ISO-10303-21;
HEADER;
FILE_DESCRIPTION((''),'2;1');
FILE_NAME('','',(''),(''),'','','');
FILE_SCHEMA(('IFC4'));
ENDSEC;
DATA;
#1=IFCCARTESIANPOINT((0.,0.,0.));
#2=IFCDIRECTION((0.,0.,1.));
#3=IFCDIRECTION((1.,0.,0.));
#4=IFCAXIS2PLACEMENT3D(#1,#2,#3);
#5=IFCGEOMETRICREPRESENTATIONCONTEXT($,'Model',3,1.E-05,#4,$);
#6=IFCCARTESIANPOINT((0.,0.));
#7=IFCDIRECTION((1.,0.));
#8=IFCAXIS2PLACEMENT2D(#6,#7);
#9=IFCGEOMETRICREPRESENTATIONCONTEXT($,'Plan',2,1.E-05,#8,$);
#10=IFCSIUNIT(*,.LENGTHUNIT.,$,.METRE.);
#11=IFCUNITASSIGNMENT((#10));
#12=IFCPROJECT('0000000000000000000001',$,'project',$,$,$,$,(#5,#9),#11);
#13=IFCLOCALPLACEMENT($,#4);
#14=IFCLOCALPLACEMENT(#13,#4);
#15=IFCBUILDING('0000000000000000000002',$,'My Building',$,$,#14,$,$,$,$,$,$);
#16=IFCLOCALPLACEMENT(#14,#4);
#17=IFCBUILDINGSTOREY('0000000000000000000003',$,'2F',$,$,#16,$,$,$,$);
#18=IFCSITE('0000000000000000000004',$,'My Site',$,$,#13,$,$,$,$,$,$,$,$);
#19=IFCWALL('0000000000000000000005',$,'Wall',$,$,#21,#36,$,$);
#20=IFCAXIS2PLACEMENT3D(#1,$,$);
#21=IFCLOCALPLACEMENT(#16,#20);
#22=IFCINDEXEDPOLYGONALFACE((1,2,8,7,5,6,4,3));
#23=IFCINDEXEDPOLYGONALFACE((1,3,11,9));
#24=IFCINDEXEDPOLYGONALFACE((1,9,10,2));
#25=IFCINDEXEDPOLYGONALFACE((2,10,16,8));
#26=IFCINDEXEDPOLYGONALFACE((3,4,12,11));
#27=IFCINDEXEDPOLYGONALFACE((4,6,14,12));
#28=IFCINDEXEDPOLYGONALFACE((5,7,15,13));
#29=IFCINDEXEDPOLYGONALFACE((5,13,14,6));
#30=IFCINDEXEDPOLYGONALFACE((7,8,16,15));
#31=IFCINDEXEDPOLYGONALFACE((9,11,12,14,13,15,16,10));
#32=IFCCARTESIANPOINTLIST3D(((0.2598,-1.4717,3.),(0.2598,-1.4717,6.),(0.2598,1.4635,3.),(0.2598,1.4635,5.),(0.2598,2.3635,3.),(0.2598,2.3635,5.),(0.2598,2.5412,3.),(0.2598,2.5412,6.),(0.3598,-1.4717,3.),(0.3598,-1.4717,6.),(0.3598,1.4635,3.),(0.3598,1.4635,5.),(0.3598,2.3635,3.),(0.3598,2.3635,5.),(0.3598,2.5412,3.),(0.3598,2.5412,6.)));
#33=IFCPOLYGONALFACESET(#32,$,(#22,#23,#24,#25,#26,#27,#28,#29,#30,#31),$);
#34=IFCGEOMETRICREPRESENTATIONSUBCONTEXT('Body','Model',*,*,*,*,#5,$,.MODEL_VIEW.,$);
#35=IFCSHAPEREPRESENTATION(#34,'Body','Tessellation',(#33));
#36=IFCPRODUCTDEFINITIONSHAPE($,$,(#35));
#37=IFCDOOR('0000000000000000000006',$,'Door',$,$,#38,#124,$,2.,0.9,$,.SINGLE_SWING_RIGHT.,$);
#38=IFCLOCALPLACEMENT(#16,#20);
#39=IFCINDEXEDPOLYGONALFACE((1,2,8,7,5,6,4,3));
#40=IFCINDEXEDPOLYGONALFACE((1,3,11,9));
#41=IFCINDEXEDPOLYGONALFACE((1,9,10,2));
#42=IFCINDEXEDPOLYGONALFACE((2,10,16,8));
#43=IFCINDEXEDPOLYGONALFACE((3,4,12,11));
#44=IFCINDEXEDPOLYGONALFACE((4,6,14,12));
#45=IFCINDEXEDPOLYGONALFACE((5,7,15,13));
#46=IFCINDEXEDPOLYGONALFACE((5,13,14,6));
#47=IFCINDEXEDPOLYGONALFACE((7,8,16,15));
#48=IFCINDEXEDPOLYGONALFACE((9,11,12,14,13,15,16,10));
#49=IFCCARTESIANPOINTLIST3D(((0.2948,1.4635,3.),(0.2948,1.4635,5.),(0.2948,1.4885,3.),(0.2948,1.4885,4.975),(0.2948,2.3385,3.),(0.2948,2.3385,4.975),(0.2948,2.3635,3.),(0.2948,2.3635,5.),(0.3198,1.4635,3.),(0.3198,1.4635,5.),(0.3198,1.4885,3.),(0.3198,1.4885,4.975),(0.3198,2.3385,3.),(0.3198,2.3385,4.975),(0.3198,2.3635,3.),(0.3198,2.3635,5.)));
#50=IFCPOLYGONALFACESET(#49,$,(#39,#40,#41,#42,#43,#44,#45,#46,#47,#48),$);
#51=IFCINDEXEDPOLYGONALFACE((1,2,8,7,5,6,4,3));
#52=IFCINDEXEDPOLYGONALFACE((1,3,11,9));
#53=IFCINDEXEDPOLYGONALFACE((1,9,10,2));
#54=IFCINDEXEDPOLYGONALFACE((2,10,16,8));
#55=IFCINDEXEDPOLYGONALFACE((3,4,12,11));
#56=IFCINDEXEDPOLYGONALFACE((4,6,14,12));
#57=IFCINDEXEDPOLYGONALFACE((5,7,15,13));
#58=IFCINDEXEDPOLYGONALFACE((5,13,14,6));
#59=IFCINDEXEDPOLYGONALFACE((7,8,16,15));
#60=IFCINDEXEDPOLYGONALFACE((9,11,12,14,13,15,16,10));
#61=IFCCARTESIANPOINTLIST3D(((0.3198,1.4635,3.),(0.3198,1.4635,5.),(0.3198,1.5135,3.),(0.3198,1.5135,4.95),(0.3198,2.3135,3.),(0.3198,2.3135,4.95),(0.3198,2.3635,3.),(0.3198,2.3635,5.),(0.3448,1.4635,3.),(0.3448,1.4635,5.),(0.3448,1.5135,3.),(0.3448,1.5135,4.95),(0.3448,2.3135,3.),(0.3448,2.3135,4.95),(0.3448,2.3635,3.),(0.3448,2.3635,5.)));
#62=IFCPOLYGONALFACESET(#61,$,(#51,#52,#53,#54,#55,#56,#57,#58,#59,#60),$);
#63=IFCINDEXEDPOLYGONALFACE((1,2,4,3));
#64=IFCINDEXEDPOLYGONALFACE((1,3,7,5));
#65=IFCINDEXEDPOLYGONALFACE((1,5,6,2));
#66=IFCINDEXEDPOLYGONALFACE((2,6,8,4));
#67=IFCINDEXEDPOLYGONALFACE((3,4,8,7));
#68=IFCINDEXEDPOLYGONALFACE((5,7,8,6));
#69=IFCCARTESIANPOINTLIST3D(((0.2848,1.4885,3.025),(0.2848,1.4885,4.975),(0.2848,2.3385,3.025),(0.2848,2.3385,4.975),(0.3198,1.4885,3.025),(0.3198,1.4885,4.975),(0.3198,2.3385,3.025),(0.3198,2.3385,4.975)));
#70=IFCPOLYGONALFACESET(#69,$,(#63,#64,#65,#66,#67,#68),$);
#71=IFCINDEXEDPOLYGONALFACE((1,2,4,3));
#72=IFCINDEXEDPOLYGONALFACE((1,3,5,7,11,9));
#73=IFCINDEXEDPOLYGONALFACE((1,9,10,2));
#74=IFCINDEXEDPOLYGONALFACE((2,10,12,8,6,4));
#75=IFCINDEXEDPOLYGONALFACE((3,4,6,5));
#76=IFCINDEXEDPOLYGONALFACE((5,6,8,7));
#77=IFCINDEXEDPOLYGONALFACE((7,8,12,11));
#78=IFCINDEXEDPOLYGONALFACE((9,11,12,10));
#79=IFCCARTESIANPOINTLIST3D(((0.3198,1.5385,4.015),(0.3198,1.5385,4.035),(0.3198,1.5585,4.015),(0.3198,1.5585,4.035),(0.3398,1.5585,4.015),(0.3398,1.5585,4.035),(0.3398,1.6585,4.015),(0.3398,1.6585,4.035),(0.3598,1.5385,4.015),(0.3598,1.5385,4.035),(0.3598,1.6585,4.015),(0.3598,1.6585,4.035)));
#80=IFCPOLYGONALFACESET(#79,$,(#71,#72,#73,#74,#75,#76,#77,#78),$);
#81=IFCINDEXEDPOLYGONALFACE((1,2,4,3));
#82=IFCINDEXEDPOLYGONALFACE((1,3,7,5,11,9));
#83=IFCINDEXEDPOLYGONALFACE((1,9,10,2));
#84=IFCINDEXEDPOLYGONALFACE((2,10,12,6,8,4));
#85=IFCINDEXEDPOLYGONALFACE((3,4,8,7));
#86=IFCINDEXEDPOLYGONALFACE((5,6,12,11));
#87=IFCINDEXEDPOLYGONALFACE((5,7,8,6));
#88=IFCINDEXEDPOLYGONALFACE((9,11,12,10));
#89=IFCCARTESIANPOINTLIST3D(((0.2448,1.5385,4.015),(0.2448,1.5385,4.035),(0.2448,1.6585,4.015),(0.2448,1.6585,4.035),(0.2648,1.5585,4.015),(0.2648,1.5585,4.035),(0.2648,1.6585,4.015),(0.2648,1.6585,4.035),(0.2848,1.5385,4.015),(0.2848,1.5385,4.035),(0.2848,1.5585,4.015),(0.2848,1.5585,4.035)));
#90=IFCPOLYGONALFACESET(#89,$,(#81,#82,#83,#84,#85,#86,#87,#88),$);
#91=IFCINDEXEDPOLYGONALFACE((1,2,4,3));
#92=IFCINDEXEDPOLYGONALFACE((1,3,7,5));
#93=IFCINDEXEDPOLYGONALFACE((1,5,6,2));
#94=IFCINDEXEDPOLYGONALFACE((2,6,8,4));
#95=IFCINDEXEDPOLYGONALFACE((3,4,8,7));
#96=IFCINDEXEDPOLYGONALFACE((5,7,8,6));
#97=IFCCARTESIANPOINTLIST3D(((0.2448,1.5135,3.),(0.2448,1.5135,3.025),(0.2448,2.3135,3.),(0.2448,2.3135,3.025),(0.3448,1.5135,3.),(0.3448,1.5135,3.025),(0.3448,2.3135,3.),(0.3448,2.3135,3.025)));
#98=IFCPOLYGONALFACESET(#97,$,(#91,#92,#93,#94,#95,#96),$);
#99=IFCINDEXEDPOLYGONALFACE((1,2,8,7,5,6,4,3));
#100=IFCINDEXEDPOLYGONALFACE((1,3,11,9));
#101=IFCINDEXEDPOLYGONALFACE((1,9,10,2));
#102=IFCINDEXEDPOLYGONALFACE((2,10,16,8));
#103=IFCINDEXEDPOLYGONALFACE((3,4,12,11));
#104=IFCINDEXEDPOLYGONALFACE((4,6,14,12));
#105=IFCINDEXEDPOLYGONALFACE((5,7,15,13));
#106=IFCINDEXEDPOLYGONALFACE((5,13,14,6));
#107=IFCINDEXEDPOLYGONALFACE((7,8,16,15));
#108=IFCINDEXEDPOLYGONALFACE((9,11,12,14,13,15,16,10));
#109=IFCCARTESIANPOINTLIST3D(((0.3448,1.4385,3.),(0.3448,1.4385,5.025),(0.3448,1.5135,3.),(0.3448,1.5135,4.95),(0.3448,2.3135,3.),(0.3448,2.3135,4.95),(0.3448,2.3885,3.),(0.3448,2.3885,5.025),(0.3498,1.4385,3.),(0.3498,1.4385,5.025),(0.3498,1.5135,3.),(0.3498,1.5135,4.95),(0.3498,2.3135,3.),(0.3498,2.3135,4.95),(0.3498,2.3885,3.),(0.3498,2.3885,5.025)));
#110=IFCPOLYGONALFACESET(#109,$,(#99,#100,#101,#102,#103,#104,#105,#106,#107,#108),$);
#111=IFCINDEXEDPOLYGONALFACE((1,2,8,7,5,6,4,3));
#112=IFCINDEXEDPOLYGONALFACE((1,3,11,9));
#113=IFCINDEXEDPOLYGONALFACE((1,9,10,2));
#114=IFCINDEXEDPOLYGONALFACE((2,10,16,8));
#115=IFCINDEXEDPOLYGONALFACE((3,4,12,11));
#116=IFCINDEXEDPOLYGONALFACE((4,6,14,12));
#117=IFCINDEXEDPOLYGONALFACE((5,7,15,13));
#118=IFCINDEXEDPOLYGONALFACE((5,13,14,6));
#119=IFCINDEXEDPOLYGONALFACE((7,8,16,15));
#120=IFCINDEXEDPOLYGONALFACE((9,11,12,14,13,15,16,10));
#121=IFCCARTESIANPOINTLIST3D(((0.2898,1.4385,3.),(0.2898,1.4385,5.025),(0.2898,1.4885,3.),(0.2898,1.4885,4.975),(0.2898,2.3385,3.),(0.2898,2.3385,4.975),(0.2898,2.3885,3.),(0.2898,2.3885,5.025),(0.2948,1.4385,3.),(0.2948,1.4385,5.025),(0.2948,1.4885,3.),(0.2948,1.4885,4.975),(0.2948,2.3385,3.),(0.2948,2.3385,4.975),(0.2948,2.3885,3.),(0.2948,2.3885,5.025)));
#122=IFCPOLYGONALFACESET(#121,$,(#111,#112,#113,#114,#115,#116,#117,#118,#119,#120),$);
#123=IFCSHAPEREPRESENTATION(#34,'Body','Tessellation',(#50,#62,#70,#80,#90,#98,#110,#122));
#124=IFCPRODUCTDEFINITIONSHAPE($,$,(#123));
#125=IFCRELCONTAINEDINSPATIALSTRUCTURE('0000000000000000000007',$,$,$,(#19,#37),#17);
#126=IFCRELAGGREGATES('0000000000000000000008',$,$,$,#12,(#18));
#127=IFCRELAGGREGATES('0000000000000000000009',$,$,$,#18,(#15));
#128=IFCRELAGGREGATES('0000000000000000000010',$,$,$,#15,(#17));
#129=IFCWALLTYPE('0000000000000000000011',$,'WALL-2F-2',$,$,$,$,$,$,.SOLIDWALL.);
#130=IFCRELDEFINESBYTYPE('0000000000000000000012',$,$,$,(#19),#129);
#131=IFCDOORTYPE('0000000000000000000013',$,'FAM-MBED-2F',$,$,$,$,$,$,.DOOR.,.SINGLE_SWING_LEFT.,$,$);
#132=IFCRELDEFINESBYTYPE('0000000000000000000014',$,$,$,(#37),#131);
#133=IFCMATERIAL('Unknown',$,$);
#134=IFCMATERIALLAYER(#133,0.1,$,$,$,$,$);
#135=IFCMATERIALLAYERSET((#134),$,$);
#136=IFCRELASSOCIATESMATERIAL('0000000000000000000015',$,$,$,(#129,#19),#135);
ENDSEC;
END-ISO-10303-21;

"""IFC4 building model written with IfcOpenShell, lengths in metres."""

from ifc_helpers import new_model, entity, si_unit, frame, origin_with_axes, origin_2d_with_axis, place, context, subcontext, project, spatial, line, indexed_curve, outline, extrude, shape, source, transform, mapped, material, layer, layer_set, layer_usage, type_object, type_shapes, element, fill, save


model = new_model("IFC4")

# Units and contexts
model_context = context("Model", 3, precision=1e-05, world=origin_with_axes())
plan_context = context("Plan", 2, precision=1e-05, world=origin_2d_with_axis())
body_context_1 = subcontext(model_context, "Body", "Model", "MODEL_VIEW")
body_context_2 = subcontext(plan_context, "Body", "Plan", "PLAN_VIEW")
ifc_project = project(units=[si_unit("LENGTHUNIT", "METRE")], contexts=[model_context, plan_context])

# Site, building, storey
site_placement = place(None, origin_with_axes())
site = spatial("IfcSite", under=ifc_project, at=site_placement, Name="My Site")
building_placement = place(site_placement, origin_with_axes())
building = spatial("IfcBuilding", under=site, at=building_placement, Name="My Building")
storey_placement = place(building_placement, origin_with_axes())
storey = spatial("IfcBuildingStorey", under=building, at=storey_placement, Name="2F")

# Shared definitions
ifc_material = material(Name="Unknown")

# Wall, opening, door
ifc_layer_1 = layer(ifc_material, 0.1)
ifc_layer_set_1 = layer_set([ifc_layer_1])
ifc_layer_usage_1 = layer_usage(ifc_layer_set_1, "AXIS2", "POSITIVE", 0.0)
wall_type_1 = type_object("IfcWallType", Name="WALL-2F-2", PredefinedType="SOLIDWALL", material=ifc_layer_set_1)
wall_1_placement = place(storey_placement, frame((0.3598, -1.4717, 3.0), z_axis=(0.0, 0.0, 1.0), x_axis=(0.0, 1.0, 0.0)))
wall_1 = element("IfcWall", 1, at=wall_1_placement, inside=storey, type_object=wall_type_1, material=ifc_layer_usage_1, Name="Wall", context=body_context_1, shape_type="SweptSolid", body=[
    extrude(outline(indexed_curve([(0.0, 0.0), (0.0, 0.1), (4.0129, 0.1), (4.0129, 0.0)], segments=[line(1, 2, 3, 4, 1)])), origin_with_axes(), (0.0, 0.0, 1.0), 3.0),
])
shared_shape_1 = source(origin_with_axes(), body_context_1, "Body", "SweptSolid", [
    extrude(outline(indexed_curve([(0.0, 0.0), (0.9, 0.0), (0.9, 2.0), (0.0, 2.0)], segments=[line(1, 2, 3, 4, 1)])), frame((0.0, -0.6, 0.0), z_axis=(0.0, -1.0, 0.0), x_axis=(1.0, 0.0, 0.0)), (0.0, 0.0, -1.0), 1.2),
])
opening_1_placement = place(wall_1_placement, frame((2.9352, 0.015, 0.0), z_axis=(0.0, 0.0, 1.0), x_axis=(1.0, 0.0, 0.0)))
opening_1 = element("IfcOpeningElement", 2, at=opening_1_placement, cuts=wall_1, PredefinedType="OPENING", context=body_context_1, shape_type="MappedRepresentation", body=[
    mapped(shared_shape_1, transform((0.0, 0.0, 0.0), x_axis=(1.0, 0.0, 0.0), y_axis=(0.0, 1.0, 0.0), z_axis=(0.0, 0.0, 1.0), scale=1.0)),
])
door_type_1 = type_object("IfcDoorType", Name="FAM-MBED-2F", OperationType="SINGLE_SWING_LEFT", PredefinedType="DOOR")
shared_shape_2 = source(origin_with_axes(), body_context_1, "Body", "SweptSolid", [
    extrude(outline(indexed_curve([(0.0, 0.0), (0.0, 2.0), (0.9, 2.0), (0.9, 0.0), (0.875, 0.0), (0.875, 1.975), (0.025, 1.975), (0.025, 0.0)], segments=[line(1, 2, 3, 4, 5, 6, 7, 8, 1)])), frame((0.0, 0.025, 0.0), z_axis=(0.0, -1.0, 0.0), x_axis=(1.0, 0.0, 0.0)), (0.0, 0.0, -1.0), 0.025),
    extrude(outline(indexed_curve([(0.0, 0.0), (0.0, 2.0), (0.9, 2.0), (0.9, 0.0), (0.85, 0.0), (0.85, 1.95), (0.05, 1.95), (0.05, 0.0)], segments=[line(1, 2, 3, 4, 5, 6, 7, 8, 1)])), frame((0.0, 0.0, 0.0), z_axis=(0.0, -1.0, 0.0), x_axis=(1.0, 0.0, 0.0)), (0.0, 0.0, -1.0), 0.025),
    extrude(outline(indexed_curve([(0.0, 0.0), (0.85, 0.0), (0.85, 0.035), (0.0, 0.035)], segments=[line(1, 2, 3, 4, 1)])), frame((0.025, 0.025, 0.025), z_axis=(0.0, 0.0, 1.0), x_axis=(1.0, 0.0, 0.0)), (0.0, 0.0, 1.0), 1.95),
    extrude(outline(indexed_curve([(0.0, 0.0), (0.0, -0.04), (0.12, -0.04), (0.12, -0.02), (0.02, -0.02), (0.02, 0.0)], segments=[line(1, 2, 3, 4, 5, 6, 1)])), frame((0.075, 0.025, 1.015), z_axis=(0.0, 0.0, 1.0), x_axis=(1.0, 0.0, 0.0)), (0.0, 0.0, 1.0), 0.02),
    extrude(outline(indexed_curve([(0.0, 0.0), (0.0, 0.04), (0.12, 0.04), (0.12, 0.02), (0.02, 0.02), (0.02, 0.0)], segments=[line(1, 2, 3, 4, 5, 6, 1)])), frame((0.075, 0.06, 1.015), z_axis=(0.0, 0.0, 1.0), x_axis=(1.0, 0.0, 0.0)), (0.0, 0.0, 1.0), 0.02),
    extrude(outline(indexed_curve([(0.0, 0.0), (0.8, 0.0), (0.8, 0.1), (0.0, 0.1)], segments=[line(1, 2, 3, 4, 1)])), frame((0.05, 0.0, 0.0), z_axis=(0.0, 0.0, 1.0), x_axis=(1.0, 0.0, 0.0)), (0.0, 0.0, 1.0), 0.025),
    extrude(outline(indexed_curve([(0.0, 0.0), (0.0, 2.025), (0.95, 2.025), (0.95, 0.0), (0.875, 0.0), (0.875, 1.95), (0.075, 1.95), (0.075, 0.0)], segments=[line(1, 2, 3, 4, 5, 6, 7, 8, 1)])), frame((-0.025, -0.005, 0.0), z_axis=(0.0, -1.0, 0.0), x_axis=(1.0, 0.0, 0.0)), (0.0, 0.0, -1.0), 0.005),
    extrude(outline(indexed_curve([(0.0, 0.0), (0.0, 2.025), (0.95, 2.025), (0.95, 0.0), (0.9, 0.0), (0.9, 1.975), (0.05, 1.975), (0.05, 0.0)], segments=[line(1, 2, 3, 4, 5, 6, 7, 8, 1)])), frame((-0.025, 0.05, 0.0), z_axis=(0.0, -1.0, 0.0), x_axis=(1.0, 0.0, 0.0)), (0.0, 0.0, -1.0), 0.005),
])
shared_shape_3 = source(origin_with_axes(), body_context_2, "Body", "Curve2D", [
    entity("IfcIndexedPolyCurve", entity("IfcCartesianPointList2D", [[0.0, 0.0], [0.0, 0.05], [0.025, 0.05], [0.025, 0.025], [0.05, 0.025], [0.05, 0.0]]), [entity("IfcLineIndex", [1, 2, 3, 4, 5, 6, 1])]),
    entity("IfcIndexedPolyCurve", entity("IfcCartesianPointList2D", [[0.9, 0.0], [0.9, 0.05], [0.875, 0.05], [0.875, 0.025], [0.85, 0.025], [0.85, 0.0]]), [entity("IfcLineIndex", [1, 2, 3, 4, 5, 6, 1])]),
    entity("IfcTrimmedCurve", entity("IfcEllipse", entity("IfcAxis2Placement2D", entity("IfcCartesianPoint", [0.84, 0.05]), entity("IfcDirection", [1.0, 0.0])), 0.815, 0.85), [entity("IfcCartesianPoint", [0.84, 0.9])], [entity("IfcCartesianPoint", [0.025, 0.05])], True, "CARTESIAN"),
    entity("IfcIndexedPolyCurve", entity("IfcCartesianPointList2D", [[0.875, 0.05], [0.84, 0.05], [0.84, 0.9], [0.875, 0.9]]), [entity("IfcLineIndex", [1, 2, 3, 4, 1])]),
])
type_shapes(door_type_1, [shared_shape_2, shared_shape_3])
door_1_placement = place(opening_1_placement, frame((0.0, 0.0, 0.0), z_axis=(0.0, 0.0, 1.0), x_axis=(1.0, 0.0, 0.0)))
door_1 = element("IfcDoor", 3, at=door_1_placement, inside=storey, type_object=door_type_1, Name="Door", OperationType="SINGLE_SWING_RIGHT", OverallHeight=2.0, OverallWidth=0.9, shapes=[
    shape(body_context_1, "Body", "MappedRepresentation", [mapped(shared_shape_2, transform((0.0, 0.0, 0.0), x_axis=(1.0, 0.0, 0.0), y_axis=(0.0, 1.0, 0.0), z_axis=(0.0, 0.0, 1.0), scale=1.0))]),
    shape(body_context_2, "Body", "MappedRepresentation", [mapped(shared_shape_3, transform((0.0, 0.0, 0.0), x_axis=(1.0, 0.0, 0.0), y_axis=(0.0, 1.0, 0.0), z_axis=(0.0, 0.0, 1.0), scale=1.0))]),
])
fill(opening_1, door_1)

save(model, "model.ifc")
